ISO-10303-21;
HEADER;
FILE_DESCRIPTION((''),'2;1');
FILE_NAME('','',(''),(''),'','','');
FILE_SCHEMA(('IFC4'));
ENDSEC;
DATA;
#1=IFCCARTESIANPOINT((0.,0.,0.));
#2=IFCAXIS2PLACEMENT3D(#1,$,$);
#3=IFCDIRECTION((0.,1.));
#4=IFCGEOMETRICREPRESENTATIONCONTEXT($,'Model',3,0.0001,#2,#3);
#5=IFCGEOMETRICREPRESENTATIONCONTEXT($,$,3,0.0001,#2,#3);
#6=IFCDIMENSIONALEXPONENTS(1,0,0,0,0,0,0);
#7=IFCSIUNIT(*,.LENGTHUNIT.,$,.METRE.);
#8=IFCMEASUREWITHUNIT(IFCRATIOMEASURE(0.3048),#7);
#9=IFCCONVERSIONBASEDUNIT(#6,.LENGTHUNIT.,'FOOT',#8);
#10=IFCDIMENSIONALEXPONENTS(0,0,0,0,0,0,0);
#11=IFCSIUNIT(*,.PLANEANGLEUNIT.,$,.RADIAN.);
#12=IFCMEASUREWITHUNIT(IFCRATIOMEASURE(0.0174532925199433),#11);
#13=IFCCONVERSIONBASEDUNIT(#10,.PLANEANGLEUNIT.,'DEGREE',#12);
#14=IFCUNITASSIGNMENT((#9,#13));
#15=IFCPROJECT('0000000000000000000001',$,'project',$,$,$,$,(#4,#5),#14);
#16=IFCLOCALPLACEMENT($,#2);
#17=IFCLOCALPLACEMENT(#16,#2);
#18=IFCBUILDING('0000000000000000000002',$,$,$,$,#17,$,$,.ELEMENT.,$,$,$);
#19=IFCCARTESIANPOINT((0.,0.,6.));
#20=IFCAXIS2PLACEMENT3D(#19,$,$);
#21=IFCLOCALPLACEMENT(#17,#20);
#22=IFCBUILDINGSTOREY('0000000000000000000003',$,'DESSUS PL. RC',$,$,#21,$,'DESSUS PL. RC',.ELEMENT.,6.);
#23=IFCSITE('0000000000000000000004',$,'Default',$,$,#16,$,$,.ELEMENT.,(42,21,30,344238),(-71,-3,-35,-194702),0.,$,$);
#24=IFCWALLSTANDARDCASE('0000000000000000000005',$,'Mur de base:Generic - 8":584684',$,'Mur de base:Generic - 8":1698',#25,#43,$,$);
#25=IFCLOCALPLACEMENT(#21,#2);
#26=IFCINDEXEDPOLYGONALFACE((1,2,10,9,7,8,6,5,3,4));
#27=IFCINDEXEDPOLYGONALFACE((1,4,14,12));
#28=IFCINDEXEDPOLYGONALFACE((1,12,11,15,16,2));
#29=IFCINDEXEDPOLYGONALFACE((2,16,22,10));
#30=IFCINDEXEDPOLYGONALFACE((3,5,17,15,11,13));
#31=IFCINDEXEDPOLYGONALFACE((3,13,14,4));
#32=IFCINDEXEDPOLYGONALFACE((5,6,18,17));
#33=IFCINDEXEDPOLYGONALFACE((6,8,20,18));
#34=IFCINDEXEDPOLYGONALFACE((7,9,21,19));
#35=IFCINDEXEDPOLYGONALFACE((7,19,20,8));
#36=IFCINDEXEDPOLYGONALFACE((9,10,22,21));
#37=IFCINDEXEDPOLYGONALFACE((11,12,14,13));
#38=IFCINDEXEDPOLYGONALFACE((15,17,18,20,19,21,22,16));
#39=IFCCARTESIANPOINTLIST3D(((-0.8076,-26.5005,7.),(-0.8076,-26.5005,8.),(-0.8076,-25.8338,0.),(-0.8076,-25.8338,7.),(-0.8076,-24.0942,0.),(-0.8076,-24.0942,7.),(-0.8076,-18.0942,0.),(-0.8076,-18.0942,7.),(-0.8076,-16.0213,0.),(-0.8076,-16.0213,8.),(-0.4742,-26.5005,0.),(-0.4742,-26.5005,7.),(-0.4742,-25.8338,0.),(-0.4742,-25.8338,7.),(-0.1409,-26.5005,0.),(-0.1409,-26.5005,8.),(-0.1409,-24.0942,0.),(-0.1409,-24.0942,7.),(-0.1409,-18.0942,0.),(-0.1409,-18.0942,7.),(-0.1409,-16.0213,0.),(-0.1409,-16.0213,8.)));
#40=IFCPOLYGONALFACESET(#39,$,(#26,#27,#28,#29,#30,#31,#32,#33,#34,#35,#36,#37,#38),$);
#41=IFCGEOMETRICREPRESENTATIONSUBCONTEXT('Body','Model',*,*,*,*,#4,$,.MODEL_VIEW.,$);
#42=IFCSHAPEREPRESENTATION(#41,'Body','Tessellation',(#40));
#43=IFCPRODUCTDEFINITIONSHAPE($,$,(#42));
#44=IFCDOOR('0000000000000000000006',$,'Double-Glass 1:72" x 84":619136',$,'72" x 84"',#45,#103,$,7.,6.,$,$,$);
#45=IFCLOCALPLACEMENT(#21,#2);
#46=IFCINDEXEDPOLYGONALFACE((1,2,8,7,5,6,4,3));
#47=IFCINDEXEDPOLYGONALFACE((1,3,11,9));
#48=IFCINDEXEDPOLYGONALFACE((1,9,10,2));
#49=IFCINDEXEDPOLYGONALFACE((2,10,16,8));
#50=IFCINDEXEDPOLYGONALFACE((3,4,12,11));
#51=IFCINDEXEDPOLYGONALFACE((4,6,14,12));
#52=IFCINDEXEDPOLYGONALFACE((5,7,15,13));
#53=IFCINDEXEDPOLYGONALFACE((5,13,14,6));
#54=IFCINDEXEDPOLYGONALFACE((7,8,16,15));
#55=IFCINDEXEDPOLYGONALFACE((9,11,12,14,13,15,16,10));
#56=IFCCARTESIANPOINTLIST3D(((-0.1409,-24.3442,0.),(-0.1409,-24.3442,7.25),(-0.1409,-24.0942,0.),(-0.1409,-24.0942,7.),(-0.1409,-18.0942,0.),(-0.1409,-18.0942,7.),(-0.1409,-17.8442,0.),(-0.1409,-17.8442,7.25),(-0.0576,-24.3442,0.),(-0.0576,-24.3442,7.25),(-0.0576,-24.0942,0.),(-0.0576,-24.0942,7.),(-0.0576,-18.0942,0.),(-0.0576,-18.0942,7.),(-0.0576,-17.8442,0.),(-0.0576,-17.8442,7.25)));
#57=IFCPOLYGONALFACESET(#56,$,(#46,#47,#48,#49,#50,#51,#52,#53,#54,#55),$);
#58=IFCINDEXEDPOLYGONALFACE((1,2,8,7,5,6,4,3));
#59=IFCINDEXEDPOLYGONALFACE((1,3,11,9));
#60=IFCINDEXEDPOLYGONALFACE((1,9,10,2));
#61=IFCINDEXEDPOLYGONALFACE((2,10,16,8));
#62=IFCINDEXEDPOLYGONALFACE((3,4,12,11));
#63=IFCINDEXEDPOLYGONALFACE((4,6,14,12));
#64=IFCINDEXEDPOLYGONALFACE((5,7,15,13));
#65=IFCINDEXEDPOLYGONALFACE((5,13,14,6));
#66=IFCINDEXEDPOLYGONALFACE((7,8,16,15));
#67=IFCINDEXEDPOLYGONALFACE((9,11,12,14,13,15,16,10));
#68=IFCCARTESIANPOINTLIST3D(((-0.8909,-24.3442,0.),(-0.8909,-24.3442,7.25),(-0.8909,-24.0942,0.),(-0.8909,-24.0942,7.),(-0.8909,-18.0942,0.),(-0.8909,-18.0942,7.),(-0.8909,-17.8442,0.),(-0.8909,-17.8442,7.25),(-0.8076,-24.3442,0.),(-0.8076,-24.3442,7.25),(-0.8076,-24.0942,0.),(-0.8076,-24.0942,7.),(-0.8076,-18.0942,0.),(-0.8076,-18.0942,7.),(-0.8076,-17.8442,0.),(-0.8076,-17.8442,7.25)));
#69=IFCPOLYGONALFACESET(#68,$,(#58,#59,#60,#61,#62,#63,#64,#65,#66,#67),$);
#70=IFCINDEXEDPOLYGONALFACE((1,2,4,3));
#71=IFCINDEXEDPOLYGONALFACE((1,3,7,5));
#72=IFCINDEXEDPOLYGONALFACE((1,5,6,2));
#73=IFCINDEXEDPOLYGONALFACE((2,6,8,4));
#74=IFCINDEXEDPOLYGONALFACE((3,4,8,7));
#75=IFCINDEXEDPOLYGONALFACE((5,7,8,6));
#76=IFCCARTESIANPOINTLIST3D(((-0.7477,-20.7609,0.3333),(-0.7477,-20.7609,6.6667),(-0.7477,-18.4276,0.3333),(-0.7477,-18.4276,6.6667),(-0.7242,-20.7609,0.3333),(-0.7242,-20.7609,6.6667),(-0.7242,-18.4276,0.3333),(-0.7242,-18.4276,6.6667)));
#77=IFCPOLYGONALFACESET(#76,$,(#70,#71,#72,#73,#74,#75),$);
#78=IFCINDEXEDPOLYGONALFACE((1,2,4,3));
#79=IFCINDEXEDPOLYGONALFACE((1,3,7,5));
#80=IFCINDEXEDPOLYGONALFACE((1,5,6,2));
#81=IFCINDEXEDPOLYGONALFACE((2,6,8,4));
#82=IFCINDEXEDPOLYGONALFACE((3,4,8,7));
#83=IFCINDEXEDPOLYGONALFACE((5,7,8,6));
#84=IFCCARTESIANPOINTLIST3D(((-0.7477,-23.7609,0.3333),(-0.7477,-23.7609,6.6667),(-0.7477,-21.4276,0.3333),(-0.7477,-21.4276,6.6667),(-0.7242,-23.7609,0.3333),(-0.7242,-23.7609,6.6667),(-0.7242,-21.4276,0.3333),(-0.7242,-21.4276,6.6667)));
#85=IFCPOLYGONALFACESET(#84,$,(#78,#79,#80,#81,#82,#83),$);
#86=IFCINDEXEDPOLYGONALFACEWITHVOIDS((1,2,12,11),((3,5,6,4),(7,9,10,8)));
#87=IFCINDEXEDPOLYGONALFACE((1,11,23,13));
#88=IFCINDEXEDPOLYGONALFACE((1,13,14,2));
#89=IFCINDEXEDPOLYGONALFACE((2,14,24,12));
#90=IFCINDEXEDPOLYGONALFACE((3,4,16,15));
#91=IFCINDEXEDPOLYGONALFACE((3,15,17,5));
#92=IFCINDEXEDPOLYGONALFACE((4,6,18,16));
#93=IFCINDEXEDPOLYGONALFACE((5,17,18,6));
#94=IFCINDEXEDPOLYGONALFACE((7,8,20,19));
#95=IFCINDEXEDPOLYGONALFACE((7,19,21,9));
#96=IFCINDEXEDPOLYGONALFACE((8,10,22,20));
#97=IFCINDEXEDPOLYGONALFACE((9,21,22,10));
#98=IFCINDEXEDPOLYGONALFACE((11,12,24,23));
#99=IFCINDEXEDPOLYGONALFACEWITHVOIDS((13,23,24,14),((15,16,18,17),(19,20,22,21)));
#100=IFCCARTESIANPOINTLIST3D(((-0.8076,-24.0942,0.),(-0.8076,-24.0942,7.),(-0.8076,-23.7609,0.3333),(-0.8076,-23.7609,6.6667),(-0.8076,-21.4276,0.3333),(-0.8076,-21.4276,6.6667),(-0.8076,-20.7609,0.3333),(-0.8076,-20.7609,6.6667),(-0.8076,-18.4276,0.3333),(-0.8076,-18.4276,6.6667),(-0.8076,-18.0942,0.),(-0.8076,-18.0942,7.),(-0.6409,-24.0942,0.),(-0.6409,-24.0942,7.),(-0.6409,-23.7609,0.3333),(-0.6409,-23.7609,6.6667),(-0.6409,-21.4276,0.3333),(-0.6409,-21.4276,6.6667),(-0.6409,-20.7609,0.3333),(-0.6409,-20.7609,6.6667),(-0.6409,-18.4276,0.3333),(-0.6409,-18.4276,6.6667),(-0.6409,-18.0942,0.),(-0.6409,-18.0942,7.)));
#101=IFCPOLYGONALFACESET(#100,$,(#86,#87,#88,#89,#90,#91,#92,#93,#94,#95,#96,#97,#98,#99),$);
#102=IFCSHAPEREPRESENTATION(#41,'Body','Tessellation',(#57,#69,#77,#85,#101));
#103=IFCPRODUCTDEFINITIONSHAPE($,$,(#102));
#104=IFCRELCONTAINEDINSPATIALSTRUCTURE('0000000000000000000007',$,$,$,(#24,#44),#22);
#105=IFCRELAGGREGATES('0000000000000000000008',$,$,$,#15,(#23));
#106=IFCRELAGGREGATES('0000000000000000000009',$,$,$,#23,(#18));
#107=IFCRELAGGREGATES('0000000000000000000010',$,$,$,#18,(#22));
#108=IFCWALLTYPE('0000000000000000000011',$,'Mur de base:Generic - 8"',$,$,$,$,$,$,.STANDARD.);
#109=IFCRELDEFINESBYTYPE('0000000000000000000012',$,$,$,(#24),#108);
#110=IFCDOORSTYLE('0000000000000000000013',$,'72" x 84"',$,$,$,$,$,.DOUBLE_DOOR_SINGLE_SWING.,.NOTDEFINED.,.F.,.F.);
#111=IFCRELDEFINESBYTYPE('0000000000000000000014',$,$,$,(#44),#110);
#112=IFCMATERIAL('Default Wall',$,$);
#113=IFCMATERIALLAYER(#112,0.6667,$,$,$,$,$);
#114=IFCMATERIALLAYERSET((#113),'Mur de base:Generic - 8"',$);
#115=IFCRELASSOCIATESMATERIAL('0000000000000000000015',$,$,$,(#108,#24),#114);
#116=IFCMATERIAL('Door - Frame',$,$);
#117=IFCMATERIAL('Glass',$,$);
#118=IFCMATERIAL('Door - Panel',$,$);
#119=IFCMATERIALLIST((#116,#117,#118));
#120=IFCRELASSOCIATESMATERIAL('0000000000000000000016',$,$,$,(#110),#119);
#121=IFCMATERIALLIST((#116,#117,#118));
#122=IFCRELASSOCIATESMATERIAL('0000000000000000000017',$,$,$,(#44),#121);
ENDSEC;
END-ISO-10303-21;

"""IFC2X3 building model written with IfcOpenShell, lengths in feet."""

from ifc_helpers import new_model, entity, si_unit, converted_unit, direction, frame, frame_2d, origin, origin_2d_with_axis, place, context, subcontext, project, spatial, polyline, rectangle, outline, extrude, source, transform, mapped, material, material_list, layer, layer_set, layer_usage, type_object, type_shapes, element, fill, save


model = new_model("IFC2X3")

# Units and contexts
model_context = context("Model", 3, precision=0.0001, world=origin(), true_north=direction((0.0, 1.0)))
context_of_model = context(None, 3, precision=0.0001, world=origin(), true_north=direction((0.0, 1.0)))
body_context = subcontext(model_context, "Body", "Model", "MODEL_VIEW")
ifc_project = project(units=[converted_unit("LENGTHUNIT", "FOOT", entity("IfcRatioMeasure", 0.3048), si_unit("LENGTHUNIT", "METRE"), dimensions=[1, 0, 0, 0, 0, 0, 0]), converted_unit("PLANEANGLEUNIT", "DEGREE", entity("IfcRatioMeasure", 0.0174532925199433), si_unit("PLANEANGLEUNIT", "RADIAN"), dimensions=[0, 0, 0, 0, 0, 0, 0])], contexts=[model_context, context_of_model])

# Site, building, storey
site_placement = place(None, origin())
site = spatial("IfcSite", under=ifc_project, at=site_placement, Name="Default", CompositionType="ELEMENT", RefLatitude=(42, 21, 30, 344238), RefLongitude=(-71, -3, -35, -194702), RefElevation=0.0)
building_placement = place(site_placement, origin())
building = spatial("IfcBuilding", under=site, at=building_placement, CompositionType="ELEMENT")
storey_placement = place(building_placement, frame((0.0, 0.0, 6.0)))
storey = spatial("IfcBuildingStorey", under=building, at=storey_placement, Name="DESSUS PL. RC", LongName="DESSUS PL. RC", CompositionType="ELEMENT", Elevation=6.0)

# Shared definitions
ifc_material_1 = material(Name="Default Wall")
ifc_material_2 = material(Name="Door - Frame")
ifc_material_3 = material(Name="Glass")
ifc_material_4 = material(Name="Door - Panel")

# Wall, openings, door
ifc_layer_1 = layer(ifc_material_1, 0.6667)
ifc_layer_set_1 = layer_set([ifc_layer_1], Name="Mur de base:Generic - 8\"")
ifc_layer_usage_1 = layer_usage(ifc_layer_set_1, "AXIS2", "NEGATIVE", 0.3333)
wall_type_1 = type_object("IfcWallType", Name="Mur de base:Generic - 8\"", PredefinedType="STANDARD", material=ifc_layer_set_1)
wall_1_placement = place(storey_placement, frame((-0.4742, -16.0213, 0.0), z_axis=(0.0, 0.0, 1.0), x_axis=(0.0, -1.0, 0.0)))
wall_1 = element("IfcWallStandardCase", 1, at=wall_1_placement, inside=storey, type_object=wall_type_1, material=ifc_layer_usage_1, Name="Mur de base:Generic - 8\":584684", ObjectType="Mur de base:Generic - 8\":1698", context=body_context, shape_type="SweptSolid", body=[
    extrude(rectangle(XDim=10.4792, YDim=0.6667, at=frame_2d((5.2396, 0.0), x_axis=(-1.0, 0.0))), origin(), (0.0, 0.0, 1.0), 8.0),
])
opening_1_placement = place(wall_1_placement, origin())
element("IfcOpeningElement", 2, at=opening_1_placement, cuts=wall_1, ObjectType="Opening", context=body_context, shape_type="SweptSolid", body=[
    extrude(rectangle(XDim=7.0, YDim=0.6667, at=frame_2d((0.0, 0.0), x_axis=(0.0, 1.0))), frame((10.1458, -6.0, 3.5), z_axis=(0.0, 1.0, 0.0), x_axis=(1.0, 0.0, 0.0)), (0.0, 0.0, 1.0), 6.0),
])
opening_2_placement = place(wall_1_placement, frame((8.0729, 0.3333, 0.0)))
opening_2 = element("IfcOpeningElement", 3, at=opening_2_placement, cuts=wall_1, ObjectType="Opening", context=body_context, shape_type="SweptSolid", body=[
    extrude(rectangle(XDim=6.0, YDim=7.0, at=frame_2d((3.5, 3.0), x_axis=(0.0, 1.0))), frame((0.0, 0.0, 0.0), z_axis=(0.0, -1.0, 0.0), x_axis=(0.0, 0.0, 1.0)), (0.0, 0.0, 1.0), 0.6667),
])
ifc_material_list_1 = material_list([ifc_material_2, ifc_material_3, ifc_material_4])
ifc_material_list_2 = material_list([ifc_material_2, ifc_material_3, ifc_material_4])
door_style_1 = type_object("IfcDoorStyle", Name="72\" x 84\"", ConstructionType="NOTDEFINED", OperationType="DOUBLE_DOOR_SINGLE_SWING", ParameterTakesPrecedence=False, Sizeable=False, material=ifc_material_list_2)
shared_shape_1 = source(origin(), body_context, "Body", "SweptSolid", [
    extrude(outline(polyline([(-3.25, -3.5625), (-3.0, -3.5625), (-3.0, 3.4375), (3.0, 3.4375), (3.0, -3.5625), (3.25, -3.5625), (3.25, 3.6875), (-3.25, 3.6875), (-3.25, -3.5625)])), frame((3.0, -0.0833, 3.5625), z_axis=(0.0, 1.0, 0.0), x_axis=(-1.0, 0.0, 0.0)), (0.0, 0.0, 1.0), 0.0833),
    extrude(outline(polyline([(-3.0, -3.4375), (-3.0, 3.5625), (-3.25, 3.5625), (-3.25, -3.6875), (3.25, -3.6875), (3.25, 3.5625), (3.0, 3.5625), (3.0, -3.4375), (-3.0, -3.4375)])), frame((3.0, 0.6667, 3.5625), z_axis=(0.0, -1.0, 0.0), x_axis=(-1.0, 0.0, 0.0)), (0.0, 0.0, -1.0), 0.0833),
    extrude(rectangle(XDim=0.0234, YDim=2.3333, at=frame_2d((0.0, 0.0), x_axis=(1.0, 0.0))), frame((4.5, 0.5951, 0.3333), z_axis=(0.0, 0.0, 1.0), x_axis=(0.0, 1.0, 0.0)), (0.0, 0.0, 1.0), 6.3333),
    extrude(rectangle(XDim=0.0234, YDim=2.3333, at=origin_2d_with_axis()), frame((1.5, 0.5951, 0.3333), z_axis=(0.0, 0.0, 1.0), x_axis=(0.0, 1.0, 0.0)), (0.0, 0.0, 1.0), 6.3333),
    extrude(outline(polyline([(-3.5, -3.0), (3.5, -3.0), (3.5, 3.0), (-3.5, 3.0), (-3.5, -3.0)]), holes=[polyline([(-3.1667, 0.3333), (-3.1667, 2.6667), (3.1667, 2.6667), (3.1667, 0.3333), (-3.1667, 0.3333)]), polyline([(-3.1667, -2.6667), (-3.1667, -0.3333), (3.1667, -0.3333), (3.1667, -2.6667), (-3.1667, -2.6667)])]), frame((3.0, 0.5, 3.5), z_axis=(0.0, 1.0, 0.0), x_axis=(0.0, 0.0, -1.0)), (0.0, 0.0, 1.0), 0.1667),
])
type_shapes(door_style_1, [shared_shape_1])
door_1_placement = place(opening_2_placement, frame((0.0, 0.0, 0.0), z_axis=(0.0, 0.0, 1.0), x_axis=(-1.0, 0.0, 0.0)))
door_1 = element("IfcDoor", 4, at=door_1_placement, inside=storey, type_object=door_style_1, material=ifc_material_list_1, Name="Double-Glass 1:72\" x 84\":619136", ObjectType="72\" x 84\"", OverallHeight=7.0, OverallWidth=6.0, context=body_context, shape_type="MappedRepresentation", body=[
    mapped(shared_shape_1, transform((0.0, 0.0, 0.0), scale=1.0)),
])
fill(opening_2, door_1)

save(model, "model.ifc")
